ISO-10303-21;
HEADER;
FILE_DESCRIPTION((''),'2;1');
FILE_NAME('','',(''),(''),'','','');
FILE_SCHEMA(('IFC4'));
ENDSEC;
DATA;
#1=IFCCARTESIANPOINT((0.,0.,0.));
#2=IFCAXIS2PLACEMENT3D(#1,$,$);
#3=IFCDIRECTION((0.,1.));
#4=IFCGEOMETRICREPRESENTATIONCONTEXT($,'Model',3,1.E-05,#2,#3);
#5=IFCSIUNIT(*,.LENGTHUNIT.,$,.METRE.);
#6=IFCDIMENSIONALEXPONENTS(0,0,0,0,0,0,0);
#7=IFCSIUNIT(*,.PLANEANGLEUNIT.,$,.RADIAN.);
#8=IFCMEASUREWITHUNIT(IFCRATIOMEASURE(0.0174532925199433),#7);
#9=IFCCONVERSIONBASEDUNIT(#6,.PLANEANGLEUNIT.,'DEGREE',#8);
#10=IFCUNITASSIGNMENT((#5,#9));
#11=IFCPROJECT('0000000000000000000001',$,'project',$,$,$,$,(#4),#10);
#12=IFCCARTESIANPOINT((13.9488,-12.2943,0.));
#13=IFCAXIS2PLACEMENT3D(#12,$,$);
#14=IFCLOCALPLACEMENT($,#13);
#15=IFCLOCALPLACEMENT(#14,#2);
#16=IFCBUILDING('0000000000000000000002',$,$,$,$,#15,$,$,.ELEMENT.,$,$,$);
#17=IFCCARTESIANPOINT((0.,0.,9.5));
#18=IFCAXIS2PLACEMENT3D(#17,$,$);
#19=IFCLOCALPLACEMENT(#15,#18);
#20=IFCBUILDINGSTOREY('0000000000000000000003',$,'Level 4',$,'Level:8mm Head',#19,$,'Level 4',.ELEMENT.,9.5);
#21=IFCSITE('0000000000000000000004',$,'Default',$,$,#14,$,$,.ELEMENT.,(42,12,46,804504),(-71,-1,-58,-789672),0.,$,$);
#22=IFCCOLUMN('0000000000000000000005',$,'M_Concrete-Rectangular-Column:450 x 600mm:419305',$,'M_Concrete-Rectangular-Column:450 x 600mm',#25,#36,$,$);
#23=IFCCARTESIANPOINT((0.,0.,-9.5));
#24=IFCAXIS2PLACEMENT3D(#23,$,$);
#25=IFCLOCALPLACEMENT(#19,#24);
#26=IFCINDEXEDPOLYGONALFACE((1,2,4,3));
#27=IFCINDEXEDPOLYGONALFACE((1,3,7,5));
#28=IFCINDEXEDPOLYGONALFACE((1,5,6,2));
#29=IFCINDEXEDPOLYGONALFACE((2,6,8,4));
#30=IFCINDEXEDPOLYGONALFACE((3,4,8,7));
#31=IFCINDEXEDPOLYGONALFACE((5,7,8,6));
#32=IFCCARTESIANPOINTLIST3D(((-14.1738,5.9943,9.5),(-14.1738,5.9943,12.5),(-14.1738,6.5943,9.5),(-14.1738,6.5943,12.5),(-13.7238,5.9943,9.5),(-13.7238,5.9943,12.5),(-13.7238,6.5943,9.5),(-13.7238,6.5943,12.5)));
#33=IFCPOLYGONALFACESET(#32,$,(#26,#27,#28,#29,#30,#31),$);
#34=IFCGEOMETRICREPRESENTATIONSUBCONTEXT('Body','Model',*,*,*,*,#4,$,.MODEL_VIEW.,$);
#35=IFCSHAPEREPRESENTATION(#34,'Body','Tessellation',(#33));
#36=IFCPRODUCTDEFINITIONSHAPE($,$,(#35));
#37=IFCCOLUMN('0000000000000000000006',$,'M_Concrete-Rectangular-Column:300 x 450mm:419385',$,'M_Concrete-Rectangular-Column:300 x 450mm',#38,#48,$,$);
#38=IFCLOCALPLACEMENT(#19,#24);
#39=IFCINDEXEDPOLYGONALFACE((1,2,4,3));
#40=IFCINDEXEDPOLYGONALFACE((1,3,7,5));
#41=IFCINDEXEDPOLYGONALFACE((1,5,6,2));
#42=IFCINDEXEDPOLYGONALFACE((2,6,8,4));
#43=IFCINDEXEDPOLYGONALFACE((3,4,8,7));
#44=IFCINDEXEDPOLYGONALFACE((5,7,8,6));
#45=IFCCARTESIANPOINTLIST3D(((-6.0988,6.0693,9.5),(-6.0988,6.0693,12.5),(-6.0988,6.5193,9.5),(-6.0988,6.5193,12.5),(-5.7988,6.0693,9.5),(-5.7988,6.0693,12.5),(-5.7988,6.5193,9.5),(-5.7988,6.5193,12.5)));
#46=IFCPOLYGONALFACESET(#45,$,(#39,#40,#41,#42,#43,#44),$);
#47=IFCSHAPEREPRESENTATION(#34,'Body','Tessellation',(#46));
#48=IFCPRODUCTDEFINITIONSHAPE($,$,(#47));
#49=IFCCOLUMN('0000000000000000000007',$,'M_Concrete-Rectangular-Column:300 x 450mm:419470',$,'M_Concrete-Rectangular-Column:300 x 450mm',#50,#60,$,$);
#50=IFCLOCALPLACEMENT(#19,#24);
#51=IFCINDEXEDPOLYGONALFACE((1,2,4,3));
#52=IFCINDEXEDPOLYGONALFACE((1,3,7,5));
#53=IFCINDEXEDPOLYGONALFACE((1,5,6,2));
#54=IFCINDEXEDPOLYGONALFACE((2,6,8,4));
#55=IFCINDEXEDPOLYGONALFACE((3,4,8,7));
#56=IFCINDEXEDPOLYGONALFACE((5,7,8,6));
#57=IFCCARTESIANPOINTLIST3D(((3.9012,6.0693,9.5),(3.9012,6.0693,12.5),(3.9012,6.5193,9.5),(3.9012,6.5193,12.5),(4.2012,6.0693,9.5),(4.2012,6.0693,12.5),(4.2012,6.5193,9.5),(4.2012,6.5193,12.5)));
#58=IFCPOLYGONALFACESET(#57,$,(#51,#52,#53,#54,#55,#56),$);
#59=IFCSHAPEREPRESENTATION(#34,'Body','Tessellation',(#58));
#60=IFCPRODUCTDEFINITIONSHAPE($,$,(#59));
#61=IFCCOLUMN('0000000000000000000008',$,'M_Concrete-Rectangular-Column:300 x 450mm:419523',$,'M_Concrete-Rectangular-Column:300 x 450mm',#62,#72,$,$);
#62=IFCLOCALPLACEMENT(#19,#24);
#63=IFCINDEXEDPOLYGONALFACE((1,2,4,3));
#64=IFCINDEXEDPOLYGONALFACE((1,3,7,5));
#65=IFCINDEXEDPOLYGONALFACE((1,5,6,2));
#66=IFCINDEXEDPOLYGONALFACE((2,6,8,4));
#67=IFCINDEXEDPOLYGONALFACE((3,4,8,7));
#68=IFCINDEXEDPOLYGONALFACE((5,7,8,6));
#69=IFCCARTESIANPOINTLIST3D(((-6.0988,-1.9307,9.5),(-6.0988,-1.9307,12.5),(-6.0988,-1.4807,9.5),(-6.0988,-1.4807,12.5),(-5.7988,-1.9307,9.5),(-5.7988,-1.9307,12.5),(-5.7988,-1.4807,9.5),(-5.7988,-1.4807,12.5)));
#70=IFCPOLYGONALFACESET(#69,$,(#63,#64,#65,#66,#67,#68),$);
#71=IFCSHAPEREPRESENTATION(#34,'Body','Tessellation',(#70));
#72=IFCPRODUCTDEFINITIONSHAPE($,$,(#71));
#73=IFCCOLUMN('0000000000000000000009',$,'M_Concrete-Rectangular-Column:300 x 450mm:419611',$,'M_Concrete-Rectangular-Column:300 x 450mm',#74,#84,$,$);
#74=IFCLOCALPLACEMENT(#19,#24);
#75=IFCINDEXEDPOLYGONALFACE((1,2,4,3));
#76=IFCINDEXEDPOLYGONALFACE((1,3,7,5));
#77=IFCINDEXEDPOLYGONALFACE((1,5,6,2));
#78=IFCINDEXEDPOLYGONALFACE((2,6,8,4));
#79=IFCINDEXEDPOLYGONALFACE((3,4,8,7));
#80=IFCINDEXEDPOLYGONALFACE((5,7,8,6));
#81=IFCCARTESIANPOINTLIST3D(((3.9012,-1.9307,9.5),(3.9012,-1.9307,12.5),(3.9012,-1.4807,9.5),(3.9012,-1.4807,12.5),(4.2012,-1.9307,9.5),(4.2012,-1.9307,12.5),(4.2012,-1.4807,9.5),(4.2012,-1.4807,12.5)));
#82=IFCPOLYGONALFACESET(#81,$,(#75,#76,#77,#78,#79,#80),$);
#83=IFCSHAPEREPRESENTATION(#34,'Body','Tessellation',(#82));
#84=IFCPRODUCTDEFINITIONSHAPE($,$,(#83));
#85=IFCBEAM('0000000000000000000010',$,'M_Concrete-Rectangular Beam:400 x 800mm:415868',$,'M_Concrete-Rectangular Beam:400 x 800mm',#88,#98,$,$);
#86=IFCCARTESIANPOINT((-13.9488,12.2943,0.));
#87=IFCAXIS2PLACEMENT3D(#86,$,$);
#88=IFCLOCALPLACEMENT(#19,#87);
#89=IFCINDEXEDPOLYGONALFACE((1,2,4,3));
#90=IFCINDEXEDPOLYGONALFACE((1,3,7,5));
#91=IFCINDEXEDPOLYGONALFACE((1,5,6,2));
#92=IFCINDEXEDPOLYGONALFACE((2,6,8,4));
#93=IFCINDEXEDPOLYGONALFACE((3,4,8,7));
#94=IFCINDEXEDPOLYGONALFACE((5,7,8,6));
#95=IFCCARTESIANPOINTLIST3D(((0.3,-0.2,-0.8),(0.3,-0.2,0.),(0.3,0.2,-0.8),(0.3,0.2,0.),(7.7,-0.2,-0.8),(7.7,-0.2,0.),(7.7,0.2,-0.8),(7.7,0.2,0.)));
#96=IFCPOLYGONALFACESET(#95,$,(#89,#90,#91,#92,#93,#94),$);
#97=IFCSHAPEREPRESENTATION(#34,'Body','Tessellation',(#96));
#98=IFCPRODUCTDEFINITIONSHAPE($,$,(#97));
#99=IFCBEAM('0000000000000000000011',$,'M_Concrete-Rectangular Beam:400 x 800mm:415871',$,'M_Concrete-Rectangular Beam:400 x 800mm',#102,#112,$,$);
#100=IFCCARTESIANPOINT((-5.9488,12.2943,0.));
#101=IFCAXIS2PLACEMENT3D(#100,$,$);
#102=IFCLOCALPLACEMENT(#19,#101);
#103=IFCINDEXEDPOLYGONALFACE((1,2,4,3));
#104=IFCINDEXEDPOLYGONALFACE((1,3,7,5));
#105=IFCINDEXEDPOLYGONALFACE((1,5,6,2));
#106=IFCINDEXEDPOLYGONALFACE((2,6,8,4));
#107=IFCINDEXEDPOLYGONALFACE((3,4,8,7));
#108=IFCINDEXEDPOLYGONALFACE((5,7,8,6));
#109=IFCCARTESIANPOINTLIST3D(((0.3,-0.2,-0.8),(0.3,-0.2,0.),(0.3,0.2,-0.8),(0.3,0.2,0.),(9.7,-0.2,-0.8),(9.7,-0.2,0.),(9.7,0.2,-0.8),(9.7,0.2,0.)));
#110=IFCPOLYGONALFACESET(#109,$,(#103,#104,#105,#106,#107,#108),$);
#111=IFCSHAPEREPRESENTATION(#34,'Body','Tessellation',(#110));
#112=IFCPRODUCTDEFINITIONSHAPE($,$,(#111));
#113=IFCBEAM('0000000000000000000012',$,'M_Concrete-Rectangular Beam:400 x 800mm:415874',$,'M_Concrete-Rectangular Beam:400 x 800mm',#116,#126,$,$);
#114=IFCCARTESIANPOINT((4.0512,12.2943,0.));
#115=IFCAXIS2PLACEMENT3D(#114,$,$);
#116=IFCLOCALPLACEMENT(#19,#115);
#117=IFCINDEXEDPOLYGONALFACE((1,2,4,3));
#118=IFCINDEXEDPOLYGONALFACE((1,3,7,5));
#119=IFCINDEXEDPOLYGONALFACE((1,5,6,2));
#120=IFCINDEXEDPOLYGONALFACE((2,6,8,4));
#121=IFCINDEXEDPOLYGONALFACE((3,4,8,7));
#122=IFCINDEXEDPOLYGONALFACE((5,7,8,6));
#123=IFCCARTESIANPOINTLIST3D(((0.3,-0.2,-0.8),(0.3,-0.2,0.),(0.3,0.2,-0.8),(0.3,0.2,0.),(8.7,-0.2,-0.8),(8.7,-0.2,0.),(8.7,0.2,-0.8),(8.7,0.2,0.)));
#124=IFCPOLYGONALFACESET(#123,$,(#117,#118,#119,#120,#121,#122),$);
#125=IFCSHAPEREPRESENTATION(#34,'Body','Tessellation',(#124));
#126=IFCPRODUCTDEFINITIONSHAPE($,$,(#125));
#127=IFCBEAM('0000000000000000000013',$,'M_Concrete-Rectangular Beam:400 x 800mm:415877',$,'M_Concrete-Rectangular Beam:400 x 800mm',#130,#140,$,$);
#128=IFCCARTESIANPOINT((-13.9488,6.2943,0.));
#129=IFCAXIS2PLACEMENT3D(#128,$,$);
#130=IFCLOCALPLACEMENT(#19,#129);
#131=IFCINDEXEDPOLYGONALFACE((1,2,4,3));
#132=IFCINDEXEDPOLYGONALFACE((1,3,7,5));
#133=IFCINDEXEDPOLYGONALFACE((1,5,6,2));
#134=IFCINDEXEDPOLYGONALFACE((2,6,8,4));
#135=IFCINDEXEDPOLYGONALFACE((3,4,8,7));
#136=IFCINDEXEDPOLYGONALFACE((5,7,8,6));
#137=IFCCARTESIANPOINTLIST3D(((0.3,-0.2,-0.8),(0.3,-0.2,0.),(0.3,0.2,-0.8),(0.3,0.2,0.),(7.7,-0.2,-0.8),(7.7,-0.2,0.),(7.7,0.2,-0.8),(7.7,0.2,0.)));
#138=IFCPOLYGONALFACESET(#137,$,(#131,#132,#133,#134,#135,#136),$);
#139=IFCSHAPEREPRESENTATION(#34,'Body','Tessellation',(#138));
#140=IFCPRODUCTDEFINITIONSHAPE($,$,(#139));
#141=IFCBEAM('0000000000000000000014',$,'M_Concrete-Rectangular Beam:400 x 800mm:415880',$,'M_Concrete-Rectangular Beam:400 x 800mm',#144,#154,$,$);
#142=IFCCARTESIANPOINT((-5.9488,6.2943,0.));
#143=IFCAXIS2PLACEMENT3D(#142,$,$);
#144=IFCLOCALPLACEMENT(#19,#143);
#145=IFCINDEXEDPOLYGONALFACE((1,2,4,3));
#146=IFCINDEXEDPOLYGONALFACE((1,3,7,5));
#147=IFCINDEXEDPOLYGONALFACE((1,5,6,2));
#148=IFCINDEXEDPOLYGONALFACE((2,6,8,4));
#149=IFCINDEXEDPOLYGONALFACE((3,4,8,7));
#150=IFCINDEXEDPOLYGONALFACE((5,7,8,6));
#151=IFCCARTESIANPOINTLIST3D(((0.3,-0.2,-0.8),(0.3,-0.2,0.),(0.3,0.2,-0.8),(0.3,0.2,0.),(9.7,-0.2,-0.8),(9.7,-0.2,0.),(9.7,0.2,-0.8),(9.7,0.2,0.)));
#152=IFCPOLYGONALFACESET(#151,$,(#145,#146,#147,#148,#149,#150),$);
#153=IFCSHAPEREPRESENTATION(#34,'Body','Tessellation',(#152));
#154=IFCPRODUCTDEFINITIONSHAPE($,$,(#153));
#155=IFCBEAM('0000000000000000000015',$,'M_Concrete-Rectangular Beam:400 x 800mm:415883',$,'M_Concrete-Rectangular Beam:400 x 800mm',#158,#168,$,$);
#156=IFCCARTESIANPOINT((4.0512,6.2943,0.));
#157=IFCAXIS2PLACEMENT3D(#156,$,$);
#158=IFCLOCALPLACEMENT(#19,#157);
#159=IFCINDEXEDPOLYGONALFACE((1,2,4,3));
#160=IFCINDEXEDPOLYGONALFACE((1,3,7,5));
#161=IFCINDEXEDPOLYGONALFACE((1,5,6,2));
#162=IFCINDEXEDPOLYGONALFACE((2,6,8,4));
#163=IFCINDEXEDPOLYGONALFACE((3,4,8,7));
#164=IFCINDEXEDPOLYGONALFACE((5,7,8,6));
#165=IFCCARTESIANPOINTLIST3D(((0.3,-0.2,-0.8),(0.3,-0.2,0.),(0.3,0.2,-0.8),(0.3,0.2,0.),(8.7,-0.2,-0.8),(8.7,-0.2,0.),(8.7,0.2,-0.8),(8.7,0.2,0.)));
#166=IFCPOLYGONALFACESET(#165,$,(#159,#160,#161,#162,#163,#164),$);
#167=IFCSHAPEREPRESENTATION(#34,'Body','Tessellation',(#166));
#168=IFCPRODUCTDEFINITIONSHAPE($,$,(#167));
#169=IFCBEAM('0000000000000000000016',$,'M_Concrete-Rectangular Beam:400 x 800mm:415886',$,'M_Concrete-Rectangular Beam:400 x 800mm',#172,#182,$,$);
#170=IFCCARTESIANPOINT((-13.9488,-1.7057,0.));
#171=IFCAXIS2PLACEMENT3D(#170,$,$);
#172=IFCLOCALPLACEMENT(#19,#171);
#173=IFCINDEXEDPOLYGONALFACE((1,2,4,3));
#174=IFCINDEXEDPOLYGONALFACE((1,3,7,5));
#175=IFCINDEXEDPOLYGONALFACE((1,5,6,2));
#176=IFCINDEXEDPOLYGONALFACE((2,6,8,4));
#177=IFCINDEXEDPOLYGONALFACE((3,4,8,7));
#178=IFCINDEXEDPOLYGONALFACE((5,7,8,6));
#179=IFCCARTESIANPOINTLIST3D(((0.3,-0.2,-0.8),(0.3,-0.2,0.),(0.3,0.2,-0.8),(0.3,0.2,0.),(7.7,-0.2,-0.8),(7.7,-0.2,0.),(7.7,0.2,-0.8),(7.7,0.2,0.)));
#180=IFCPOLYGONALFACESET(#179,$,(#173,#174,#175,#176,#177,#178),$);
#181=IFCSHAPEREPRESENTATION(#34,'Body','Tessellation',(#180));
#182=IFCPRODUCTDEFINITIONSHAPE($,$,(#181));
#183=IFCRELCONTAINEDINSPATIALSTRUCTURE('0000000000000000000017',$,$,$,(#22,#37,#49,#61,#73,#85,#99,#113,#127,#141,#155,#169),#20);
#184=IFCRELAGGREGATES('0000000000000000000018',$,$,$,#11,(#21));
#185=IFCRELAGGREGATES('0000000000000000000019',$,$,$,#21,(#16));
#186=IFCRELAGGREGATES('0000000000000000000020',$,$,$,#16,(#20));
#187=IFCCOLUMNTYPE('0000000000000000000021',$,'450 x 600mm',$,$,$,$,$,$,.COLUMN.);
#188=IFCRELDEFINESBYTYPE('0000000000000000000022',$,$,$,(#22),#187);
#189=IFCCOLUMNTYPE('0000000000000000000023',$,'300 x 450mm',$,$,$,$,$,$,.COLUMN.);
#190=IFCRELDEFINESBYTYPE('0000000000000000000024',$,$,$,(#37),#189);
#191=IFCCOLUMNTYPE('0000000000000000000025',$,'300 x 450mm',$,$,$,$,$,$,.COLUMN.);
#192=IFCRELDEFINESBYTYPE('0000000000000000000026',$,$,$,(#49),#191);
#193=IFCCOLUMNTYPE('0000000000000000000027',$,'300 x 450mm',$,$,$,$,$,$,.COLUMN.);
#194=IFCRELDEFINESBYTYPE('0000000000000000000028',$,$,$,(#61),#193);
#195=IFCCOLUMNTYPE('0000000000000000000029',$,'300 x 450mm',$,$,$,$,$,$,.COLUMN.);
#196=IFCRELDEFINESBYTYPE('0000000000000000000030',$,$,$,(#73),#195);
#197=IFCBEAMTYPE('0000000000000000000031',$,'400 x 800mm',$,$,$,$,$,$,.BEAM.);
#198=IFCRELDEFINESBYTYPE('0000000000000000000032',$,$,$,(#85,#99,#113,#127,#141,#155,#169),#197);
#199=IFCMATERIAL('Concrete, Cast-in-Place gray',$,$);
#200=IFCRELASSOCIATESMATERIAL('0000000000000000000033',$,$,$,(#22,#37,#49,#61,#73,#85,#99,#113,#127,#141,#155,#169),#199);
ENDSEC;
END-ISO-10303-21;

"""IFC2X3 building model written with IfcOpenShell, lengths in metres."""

from ifc_helpers import new_model, entity, si_unit, converted_unit, direction, frame, frame_2d, origin, origin_2d_with_axis, place, context, subcontext, project, spatial, rectangle, extrude, source, transform, mapped, material, type_object, type_shapes, element, save


model = new_model("IFC2X3")

# Units and contexts
model_context = context("Model", 3, precision=1e-05, world=origin(), true_north=direction((0.0, 1.0)))
body_context = subcontext(model_context, "Body", "Model", "MODEL_VIEW")
ifc_project = project(units=[si_unit("LENGTHUNIT", "METRE"), converted_unit("PLANEANGLEUNIT", "DEGREE", entity("IfcRatioMeasure", 0.0174532925199433), si_unit("PLANEANGLEUNIT", "RADIAN"), dimensions=[0, 0, 0, 0, 0, 0, 0])], contexts=[model_context])

# Site, building, storey
site_placement = place(None, frame((13.9488, -12.2943, 0.0)))
site = spatial("IfcSite", under=ifc_project, at=site_placement, Name="Default", CompositionType="ELEMENT", RefLatitude=(42, 12, 46, 804504), RefLongitude=(-71, -1, -58, -789672), RefElevation=0.0)
building_placement = place(site_placement, origin())
building = spatial("IfcBuilding", under=site, at=building_placement, CompositionType="ELEMENT")
storey_placement = place(building_placement, frame((0.0, 0.0, 9.5)))
storey = spatial("IfcBuildingStorey", under=building, at=storey_placement, Name="Level 4", ObjectType="Level:8mm Head", LongName="Level 4", CompositionType="ELEMENT", Elevation=9.5)

# Columns
ifc_material = material(Name="Concrete, Cast-in-Place gray")
column_type_1 = type_object("IfcColumnType", Name="450 x 600mm", PredefinedType="COLUMN")
shared_shape_1 = source(origin(), body_context, "Body", "SweptSolid", [
    extrude(rectangle(XDim=0.6, YDim=0.45, at=origin_2d_with_axis()), frame((-13.9488, 6.2943, 9.5), z_axis=(0.0, 0.0, 1.0), x_axis=(0.0, -1.0, 0.0)), (0.0, 0.0, 1.0), 3.0),
])
type_shapes(column_type_1, [shared_shape_1])
column_1_placement = place(storey_placement, frame((0.0, 0.0, -9.5)))
element("IfcColumn", 1, at=column_1_placement, inside=storey, type_object=column_type_1, material=ifc_material, Name="M_Concrete-Rectangular-Column:450 x 600mm:419305", ObjectType="M_Concrete-Rectangular-Column:450 x 600mm", context=body_context, shape_type="MappedRepresentation", body=[
    mapped(shared_shape_1, transform((0.0, 0.0, 0.0), scale=1.0)),
])
column_type_2 = type_object("IfcColumnType", Name="300 x 450mm", PredefinedType="COLUMN")
shared_shape_2 = source(origin(), body_context, "Body", "SweptSolid", [
    extrude(rectangle(XDim=0.45, YDim=0.3, at=frame_2d((0.0, 0.0), x_axis=(1.0, 0.0))), frame((-5.9488, 6.2943, 9.5), z_axis=(0.0, 0.0, 1.0), x_axis=(0.0, -1.0, 0.0)), (0.0, 0.0, 1.0), 3.0),
])
type_shapes(column_type_2, [shared_shape_2])
column_2_placement = place(storey_placement, frame((0.0, 0.0, -9.5)))
element("IfcColumn", 2, at=column_2_placement, inside=storey, type_object=column_type_2, material=ifc_material, Name="M_Concrete-Rectangular-Column:300 x 450mm:419385", ObjectType="M_Concrete-Rectangular-Column:300 x 450mm", context=body_context, shape_type="MappedRepresentation", body=[
    mapped(shared_shape_2, transform((0.0, 0.0, 0.0), scale=1.0)),
])
column_type_3 = type_object("IfcColumnType", Name="300 x 450mm", PredefinedType="COLUMN")
shared_shape_3 = source(origin(), body_context, "Body", "SweptSolid", [
    extrude(rectangle(XDim=0.45, YDim=0.3, at=origin_2d_with_axis()), frame((4.0512, 6.2943, 9.5), z_axis=(0.0, 0.0, 1.0), x_axis=(0.0, -1.0, 0.0)), (0.0, 0.0, 1.0), 3.0),
])
type_shapes(column_type_3, [shared_shape_3])
column_3_placement = place(storey_placement, frame((0.0, 0.0, -9.5)))
element("IfcColumn", 3, at=column_3_placement, inside=storey, type_object=column_type_3, material=ifc_material, Name="M_Concrete-Rectangular-Column:300 x 450mm:419470", ObjectType="M_Concrete-Rectangular-Column:300 x 450mm", context=body_context, shape_type="MappedRepresentation", body=[
    mapped(shared_shape_3, transform((0.0, 0.0, 0.0), scale=1.0)),
])
column_type_4 = type_object("IfcColumnType", Name="300 x 450mm", PredefinedType="COLUMN")
shared_shape_4 = source(origin(), body_context, "Body", "SweptSolid", [
    extrude(rectangle(XDim=0.45, YDim=0.3, at=frame_2d((0.0, 0.0), x_axis=(1.0, 0.0))), frame((-5.9488, -1.7057, 9.5), z_axis=(0.0, 0.0, 1.0), x_axis=(0.0, -1.0, 0.0)), (0.0, 0.0, 1.0), 3.0),
])
type_shapes(column_type_4, [shared_shape_4])
column_4_placement = place(storey_placement, frame((0.0, 0.0, -9.5)))
element("IfcColumn", 4, at=column_4_placement, inside=storey, type_object=column_type_4, material=ifc_material, Name="M_Concrete-Rectangular-Column:300 x 450mm:419523", ObjectType="M_Concrete-Rectangular-Column:300 x 450mm", context=body_context, shape_type="MappedRepresentation", body=[
    mapped(shared_shape_4, transform((0.0, 0.0, 0.0), scale=1.0)),
])
column_type_5 = type_object("IfcColumnType", Name="300 x 450mm", PredefinedType="COLUMN")
shared_shape_5 = source(origin(), body_context, "Body", "SweptSolid", [
    extrude(rectangle(XDim=0.45, YDim=0.3, at=frame_2d((0.0, 0.0), x_axis=(1.0, 0.0))), frame((4.0512, -1.7057, 9.5), z_axis=(0.0, 0.0, 1.0), x_axis=(0.0, -1.0, 0.0)), (0.0, 0.0, 1.0), 3.0),
])
type_shapes(column_type_5, [shared_shape_5])
column_5_placement = place(storey_placement, frame((0.0, 0.0, -9.5)))
element("IfcColumn", 5, at=column_5_placement, inside=storey, type_object=column_type_5, material=ifc_material, Name="M_Concrete-Rectangular-Column:300 x 450mm:419611", ObjectType="M_Concrete-Rectangular-Column:300 x 450mm", context=body_context, shape_type="MappedRepresentation", body=[
    mapped(shared_shape_5, transform((0.0, 0.0, 0.0), scale=1.0)),
])

# Beams
beam_type_1 = type_object("IfcBeamType", Name="400 x 800mm", PredefinedType="BEAM")
beam_1_placement = place(storey_placement, frame((-13.9488, 12.2943, 0.0)))
element("IfcBeam", 6, at=beam_1_placement, inside=storey, type_object=beam_type_1, material=ifc_material, Name="M_Concrete-Rectangular Beam:400 x 800mm:415868", ObjectType="M_Concrete-Rectangular Beam:400 x 800mm", context=body_context, shape_type="SweptSolid", body=[
    extrude(rectangle(XDim=0.8, YDim=0.4, at=frame_2d((0.0, 0.0), x_axis=(1.0, 0.0))), frame((0.3, 0.0, -0.4), z_axis=(1.0, 0.0, 0.0), x_axis=(0.0, 0.0, -1.0)), (0.0, 0.0, 1.0), 7.4),
])
beam_2_placement = place(storey_placement, frame((-5.9488, 12.2943, 0.0)))
element("IfcBeam", 7, at=beam_2_placement, inside=storey, type_object=beam_type_1, material=ifc_material, Name="M_Concrete-Rectangular Beam:400 x 800mm:415871", ObjectType="M_Concrete-Rectangular Beam:400 x 800mm", context=body_context, shape_type="SweptSolid", body=[
    extrude(rectangle(XDim=0.8, YDim=0.4, at=frame_2d((0.0, 0.0), x_axis=(1.0, 0.0))), frame((0.3, 0.0, -0.4), z_axis=(1.0, 0.0, 0.0), x_axis=(0.0, 0.0, -1.0)), (0.0, 0.0, 1.0), 9.4),
])
beam_3_placement = place(storey_placement, frame((4.0512, 12.2943, 0.0)))
element("IfcBeam", 8, at=beam_3_placement, inside=storey, type_object=beam_type_1, material=ifc_material, Name="M_Concrete-Rectangular Beam:400 x 800mm:415874", ObjectType="M_Concrete-Rectangular Beam:400 x 800mm", context=body_context, shape_type="SweptSolid", body=[
    extrude(rectangle(XDim=0.8, YDim=0.4, at=frame_2d((0.0, 0.0), x_axis=(1.0, 0.0))), frame((0.3, 0.0, -0.4), z_axis=(1.0, 0.0, 0.0), x_axis=(0.0, 0.0, -1.0)), (0.0, 0.0, 1.0), 8.4),
])
beam_4_placement = place(storey_placement, frame((-13.9488, 6.2943, 0.0)))
element("IfcBeam", 9, at=beam_4_placement, inside=storey, type_object=beam_type_1, material=ifc_material, Name="M_Concrete-Rectangular Beam:400 x 800mm:415877", ObjectType="M_Concrete-Rectangular Beam:400 x 800mm", context=body_context, shape_type="SweptSolid", body=[
    extrude(rectangle(XDim=0.8, YDim=0.4, at=frame_2d((0.0, 0.0), x_axis=(1.0, 0.0))), frame((0.3, 0.0, -0.4), z_axis=(1.0, 0.0, 0.0), x_axis=(0.0, 0.0, -1.0)), (0.0, 0.0, 1.0), 7.4),
])
beam_5_placement = place(storey_placement, frame((-5.9488, 6.2943, 0.0)))
element("IfcBeam", 10, at=beam_5_placement, inside=storey, type_object=beam_type_1, material=ifc_material, Name="M_Concrete-Rectangular Beam:400 x 800mm:415880", ObjectType="M_Concrete-Rectangular Beam:400 x 800mm", context=body_context, shape_type="SweptSolid", body=[
    extrude(rectangle(XDim=0.8, YDim=0.4, at=frame_2d((0.0, 0.0), x_axis=(1.0, 0.0))), frame((0.3, 0.0, -0.4), z_axis=(1.0, 0.0, 0.0), x_axis=(0.0, 0.0, -1.0)), (0.0, 0.0, 1.0), 9.4),
])
beam_6_placement = place(storey_placement, frame((4.0512, 6.2943, 0.0)))
element("IfcBeam", 11, at=beam_6_placement, inside=storey, type_object=beam_type_1, material=ifc_material, Name="M_Concrete-Rectangular Beam:400 x 800mm:415883", ObjectType="M_Concrete-Rectangular Beam:400 x 800mm", context=body_context, shape_type="SweptSolid", body=[
    extrude(rectangle(XDim=0.8, YDim=0.4, at=frame_2d((0.0, 0.0), x_axis=(1.0, 0.0))), frame((0.3, 0.0, -0.4), z_axis=(1.0, 0.0, 0.0), x_axis=(0.0, 0.0, -1.0)), (0.0, 0.0, 1.0), 8.4),
])
beam_7_placement = place(storey_placement, frame((-13.9488, -1.7057, 0.0)))
element("IfcBeam", 12, at=beam_7_placement, inside=storey, type_object=beam_type_1, material=ifc_material, Name="M_Concrete-Rectangular Beam:400 x 800mm:415886", ObjectType="M_Concrete-Rectangular Beam:400 x 800mm", context=body_context, shape_type="SweptSolid", body=[
    extrude(rectangle(XDim=0.8, YDim=0.4, at=frame_2d((0.0, 0.0), x_axis=(1.0, 0.0))), frame((0.3, 0.0, -0.4), z_axis=(1.0, 0.0, 0.0), x_axis=(0.0, 0.0, -1.0)), (0.0, 0.0, 1.0), 7.4),
])

save(model, "model.ifc")
